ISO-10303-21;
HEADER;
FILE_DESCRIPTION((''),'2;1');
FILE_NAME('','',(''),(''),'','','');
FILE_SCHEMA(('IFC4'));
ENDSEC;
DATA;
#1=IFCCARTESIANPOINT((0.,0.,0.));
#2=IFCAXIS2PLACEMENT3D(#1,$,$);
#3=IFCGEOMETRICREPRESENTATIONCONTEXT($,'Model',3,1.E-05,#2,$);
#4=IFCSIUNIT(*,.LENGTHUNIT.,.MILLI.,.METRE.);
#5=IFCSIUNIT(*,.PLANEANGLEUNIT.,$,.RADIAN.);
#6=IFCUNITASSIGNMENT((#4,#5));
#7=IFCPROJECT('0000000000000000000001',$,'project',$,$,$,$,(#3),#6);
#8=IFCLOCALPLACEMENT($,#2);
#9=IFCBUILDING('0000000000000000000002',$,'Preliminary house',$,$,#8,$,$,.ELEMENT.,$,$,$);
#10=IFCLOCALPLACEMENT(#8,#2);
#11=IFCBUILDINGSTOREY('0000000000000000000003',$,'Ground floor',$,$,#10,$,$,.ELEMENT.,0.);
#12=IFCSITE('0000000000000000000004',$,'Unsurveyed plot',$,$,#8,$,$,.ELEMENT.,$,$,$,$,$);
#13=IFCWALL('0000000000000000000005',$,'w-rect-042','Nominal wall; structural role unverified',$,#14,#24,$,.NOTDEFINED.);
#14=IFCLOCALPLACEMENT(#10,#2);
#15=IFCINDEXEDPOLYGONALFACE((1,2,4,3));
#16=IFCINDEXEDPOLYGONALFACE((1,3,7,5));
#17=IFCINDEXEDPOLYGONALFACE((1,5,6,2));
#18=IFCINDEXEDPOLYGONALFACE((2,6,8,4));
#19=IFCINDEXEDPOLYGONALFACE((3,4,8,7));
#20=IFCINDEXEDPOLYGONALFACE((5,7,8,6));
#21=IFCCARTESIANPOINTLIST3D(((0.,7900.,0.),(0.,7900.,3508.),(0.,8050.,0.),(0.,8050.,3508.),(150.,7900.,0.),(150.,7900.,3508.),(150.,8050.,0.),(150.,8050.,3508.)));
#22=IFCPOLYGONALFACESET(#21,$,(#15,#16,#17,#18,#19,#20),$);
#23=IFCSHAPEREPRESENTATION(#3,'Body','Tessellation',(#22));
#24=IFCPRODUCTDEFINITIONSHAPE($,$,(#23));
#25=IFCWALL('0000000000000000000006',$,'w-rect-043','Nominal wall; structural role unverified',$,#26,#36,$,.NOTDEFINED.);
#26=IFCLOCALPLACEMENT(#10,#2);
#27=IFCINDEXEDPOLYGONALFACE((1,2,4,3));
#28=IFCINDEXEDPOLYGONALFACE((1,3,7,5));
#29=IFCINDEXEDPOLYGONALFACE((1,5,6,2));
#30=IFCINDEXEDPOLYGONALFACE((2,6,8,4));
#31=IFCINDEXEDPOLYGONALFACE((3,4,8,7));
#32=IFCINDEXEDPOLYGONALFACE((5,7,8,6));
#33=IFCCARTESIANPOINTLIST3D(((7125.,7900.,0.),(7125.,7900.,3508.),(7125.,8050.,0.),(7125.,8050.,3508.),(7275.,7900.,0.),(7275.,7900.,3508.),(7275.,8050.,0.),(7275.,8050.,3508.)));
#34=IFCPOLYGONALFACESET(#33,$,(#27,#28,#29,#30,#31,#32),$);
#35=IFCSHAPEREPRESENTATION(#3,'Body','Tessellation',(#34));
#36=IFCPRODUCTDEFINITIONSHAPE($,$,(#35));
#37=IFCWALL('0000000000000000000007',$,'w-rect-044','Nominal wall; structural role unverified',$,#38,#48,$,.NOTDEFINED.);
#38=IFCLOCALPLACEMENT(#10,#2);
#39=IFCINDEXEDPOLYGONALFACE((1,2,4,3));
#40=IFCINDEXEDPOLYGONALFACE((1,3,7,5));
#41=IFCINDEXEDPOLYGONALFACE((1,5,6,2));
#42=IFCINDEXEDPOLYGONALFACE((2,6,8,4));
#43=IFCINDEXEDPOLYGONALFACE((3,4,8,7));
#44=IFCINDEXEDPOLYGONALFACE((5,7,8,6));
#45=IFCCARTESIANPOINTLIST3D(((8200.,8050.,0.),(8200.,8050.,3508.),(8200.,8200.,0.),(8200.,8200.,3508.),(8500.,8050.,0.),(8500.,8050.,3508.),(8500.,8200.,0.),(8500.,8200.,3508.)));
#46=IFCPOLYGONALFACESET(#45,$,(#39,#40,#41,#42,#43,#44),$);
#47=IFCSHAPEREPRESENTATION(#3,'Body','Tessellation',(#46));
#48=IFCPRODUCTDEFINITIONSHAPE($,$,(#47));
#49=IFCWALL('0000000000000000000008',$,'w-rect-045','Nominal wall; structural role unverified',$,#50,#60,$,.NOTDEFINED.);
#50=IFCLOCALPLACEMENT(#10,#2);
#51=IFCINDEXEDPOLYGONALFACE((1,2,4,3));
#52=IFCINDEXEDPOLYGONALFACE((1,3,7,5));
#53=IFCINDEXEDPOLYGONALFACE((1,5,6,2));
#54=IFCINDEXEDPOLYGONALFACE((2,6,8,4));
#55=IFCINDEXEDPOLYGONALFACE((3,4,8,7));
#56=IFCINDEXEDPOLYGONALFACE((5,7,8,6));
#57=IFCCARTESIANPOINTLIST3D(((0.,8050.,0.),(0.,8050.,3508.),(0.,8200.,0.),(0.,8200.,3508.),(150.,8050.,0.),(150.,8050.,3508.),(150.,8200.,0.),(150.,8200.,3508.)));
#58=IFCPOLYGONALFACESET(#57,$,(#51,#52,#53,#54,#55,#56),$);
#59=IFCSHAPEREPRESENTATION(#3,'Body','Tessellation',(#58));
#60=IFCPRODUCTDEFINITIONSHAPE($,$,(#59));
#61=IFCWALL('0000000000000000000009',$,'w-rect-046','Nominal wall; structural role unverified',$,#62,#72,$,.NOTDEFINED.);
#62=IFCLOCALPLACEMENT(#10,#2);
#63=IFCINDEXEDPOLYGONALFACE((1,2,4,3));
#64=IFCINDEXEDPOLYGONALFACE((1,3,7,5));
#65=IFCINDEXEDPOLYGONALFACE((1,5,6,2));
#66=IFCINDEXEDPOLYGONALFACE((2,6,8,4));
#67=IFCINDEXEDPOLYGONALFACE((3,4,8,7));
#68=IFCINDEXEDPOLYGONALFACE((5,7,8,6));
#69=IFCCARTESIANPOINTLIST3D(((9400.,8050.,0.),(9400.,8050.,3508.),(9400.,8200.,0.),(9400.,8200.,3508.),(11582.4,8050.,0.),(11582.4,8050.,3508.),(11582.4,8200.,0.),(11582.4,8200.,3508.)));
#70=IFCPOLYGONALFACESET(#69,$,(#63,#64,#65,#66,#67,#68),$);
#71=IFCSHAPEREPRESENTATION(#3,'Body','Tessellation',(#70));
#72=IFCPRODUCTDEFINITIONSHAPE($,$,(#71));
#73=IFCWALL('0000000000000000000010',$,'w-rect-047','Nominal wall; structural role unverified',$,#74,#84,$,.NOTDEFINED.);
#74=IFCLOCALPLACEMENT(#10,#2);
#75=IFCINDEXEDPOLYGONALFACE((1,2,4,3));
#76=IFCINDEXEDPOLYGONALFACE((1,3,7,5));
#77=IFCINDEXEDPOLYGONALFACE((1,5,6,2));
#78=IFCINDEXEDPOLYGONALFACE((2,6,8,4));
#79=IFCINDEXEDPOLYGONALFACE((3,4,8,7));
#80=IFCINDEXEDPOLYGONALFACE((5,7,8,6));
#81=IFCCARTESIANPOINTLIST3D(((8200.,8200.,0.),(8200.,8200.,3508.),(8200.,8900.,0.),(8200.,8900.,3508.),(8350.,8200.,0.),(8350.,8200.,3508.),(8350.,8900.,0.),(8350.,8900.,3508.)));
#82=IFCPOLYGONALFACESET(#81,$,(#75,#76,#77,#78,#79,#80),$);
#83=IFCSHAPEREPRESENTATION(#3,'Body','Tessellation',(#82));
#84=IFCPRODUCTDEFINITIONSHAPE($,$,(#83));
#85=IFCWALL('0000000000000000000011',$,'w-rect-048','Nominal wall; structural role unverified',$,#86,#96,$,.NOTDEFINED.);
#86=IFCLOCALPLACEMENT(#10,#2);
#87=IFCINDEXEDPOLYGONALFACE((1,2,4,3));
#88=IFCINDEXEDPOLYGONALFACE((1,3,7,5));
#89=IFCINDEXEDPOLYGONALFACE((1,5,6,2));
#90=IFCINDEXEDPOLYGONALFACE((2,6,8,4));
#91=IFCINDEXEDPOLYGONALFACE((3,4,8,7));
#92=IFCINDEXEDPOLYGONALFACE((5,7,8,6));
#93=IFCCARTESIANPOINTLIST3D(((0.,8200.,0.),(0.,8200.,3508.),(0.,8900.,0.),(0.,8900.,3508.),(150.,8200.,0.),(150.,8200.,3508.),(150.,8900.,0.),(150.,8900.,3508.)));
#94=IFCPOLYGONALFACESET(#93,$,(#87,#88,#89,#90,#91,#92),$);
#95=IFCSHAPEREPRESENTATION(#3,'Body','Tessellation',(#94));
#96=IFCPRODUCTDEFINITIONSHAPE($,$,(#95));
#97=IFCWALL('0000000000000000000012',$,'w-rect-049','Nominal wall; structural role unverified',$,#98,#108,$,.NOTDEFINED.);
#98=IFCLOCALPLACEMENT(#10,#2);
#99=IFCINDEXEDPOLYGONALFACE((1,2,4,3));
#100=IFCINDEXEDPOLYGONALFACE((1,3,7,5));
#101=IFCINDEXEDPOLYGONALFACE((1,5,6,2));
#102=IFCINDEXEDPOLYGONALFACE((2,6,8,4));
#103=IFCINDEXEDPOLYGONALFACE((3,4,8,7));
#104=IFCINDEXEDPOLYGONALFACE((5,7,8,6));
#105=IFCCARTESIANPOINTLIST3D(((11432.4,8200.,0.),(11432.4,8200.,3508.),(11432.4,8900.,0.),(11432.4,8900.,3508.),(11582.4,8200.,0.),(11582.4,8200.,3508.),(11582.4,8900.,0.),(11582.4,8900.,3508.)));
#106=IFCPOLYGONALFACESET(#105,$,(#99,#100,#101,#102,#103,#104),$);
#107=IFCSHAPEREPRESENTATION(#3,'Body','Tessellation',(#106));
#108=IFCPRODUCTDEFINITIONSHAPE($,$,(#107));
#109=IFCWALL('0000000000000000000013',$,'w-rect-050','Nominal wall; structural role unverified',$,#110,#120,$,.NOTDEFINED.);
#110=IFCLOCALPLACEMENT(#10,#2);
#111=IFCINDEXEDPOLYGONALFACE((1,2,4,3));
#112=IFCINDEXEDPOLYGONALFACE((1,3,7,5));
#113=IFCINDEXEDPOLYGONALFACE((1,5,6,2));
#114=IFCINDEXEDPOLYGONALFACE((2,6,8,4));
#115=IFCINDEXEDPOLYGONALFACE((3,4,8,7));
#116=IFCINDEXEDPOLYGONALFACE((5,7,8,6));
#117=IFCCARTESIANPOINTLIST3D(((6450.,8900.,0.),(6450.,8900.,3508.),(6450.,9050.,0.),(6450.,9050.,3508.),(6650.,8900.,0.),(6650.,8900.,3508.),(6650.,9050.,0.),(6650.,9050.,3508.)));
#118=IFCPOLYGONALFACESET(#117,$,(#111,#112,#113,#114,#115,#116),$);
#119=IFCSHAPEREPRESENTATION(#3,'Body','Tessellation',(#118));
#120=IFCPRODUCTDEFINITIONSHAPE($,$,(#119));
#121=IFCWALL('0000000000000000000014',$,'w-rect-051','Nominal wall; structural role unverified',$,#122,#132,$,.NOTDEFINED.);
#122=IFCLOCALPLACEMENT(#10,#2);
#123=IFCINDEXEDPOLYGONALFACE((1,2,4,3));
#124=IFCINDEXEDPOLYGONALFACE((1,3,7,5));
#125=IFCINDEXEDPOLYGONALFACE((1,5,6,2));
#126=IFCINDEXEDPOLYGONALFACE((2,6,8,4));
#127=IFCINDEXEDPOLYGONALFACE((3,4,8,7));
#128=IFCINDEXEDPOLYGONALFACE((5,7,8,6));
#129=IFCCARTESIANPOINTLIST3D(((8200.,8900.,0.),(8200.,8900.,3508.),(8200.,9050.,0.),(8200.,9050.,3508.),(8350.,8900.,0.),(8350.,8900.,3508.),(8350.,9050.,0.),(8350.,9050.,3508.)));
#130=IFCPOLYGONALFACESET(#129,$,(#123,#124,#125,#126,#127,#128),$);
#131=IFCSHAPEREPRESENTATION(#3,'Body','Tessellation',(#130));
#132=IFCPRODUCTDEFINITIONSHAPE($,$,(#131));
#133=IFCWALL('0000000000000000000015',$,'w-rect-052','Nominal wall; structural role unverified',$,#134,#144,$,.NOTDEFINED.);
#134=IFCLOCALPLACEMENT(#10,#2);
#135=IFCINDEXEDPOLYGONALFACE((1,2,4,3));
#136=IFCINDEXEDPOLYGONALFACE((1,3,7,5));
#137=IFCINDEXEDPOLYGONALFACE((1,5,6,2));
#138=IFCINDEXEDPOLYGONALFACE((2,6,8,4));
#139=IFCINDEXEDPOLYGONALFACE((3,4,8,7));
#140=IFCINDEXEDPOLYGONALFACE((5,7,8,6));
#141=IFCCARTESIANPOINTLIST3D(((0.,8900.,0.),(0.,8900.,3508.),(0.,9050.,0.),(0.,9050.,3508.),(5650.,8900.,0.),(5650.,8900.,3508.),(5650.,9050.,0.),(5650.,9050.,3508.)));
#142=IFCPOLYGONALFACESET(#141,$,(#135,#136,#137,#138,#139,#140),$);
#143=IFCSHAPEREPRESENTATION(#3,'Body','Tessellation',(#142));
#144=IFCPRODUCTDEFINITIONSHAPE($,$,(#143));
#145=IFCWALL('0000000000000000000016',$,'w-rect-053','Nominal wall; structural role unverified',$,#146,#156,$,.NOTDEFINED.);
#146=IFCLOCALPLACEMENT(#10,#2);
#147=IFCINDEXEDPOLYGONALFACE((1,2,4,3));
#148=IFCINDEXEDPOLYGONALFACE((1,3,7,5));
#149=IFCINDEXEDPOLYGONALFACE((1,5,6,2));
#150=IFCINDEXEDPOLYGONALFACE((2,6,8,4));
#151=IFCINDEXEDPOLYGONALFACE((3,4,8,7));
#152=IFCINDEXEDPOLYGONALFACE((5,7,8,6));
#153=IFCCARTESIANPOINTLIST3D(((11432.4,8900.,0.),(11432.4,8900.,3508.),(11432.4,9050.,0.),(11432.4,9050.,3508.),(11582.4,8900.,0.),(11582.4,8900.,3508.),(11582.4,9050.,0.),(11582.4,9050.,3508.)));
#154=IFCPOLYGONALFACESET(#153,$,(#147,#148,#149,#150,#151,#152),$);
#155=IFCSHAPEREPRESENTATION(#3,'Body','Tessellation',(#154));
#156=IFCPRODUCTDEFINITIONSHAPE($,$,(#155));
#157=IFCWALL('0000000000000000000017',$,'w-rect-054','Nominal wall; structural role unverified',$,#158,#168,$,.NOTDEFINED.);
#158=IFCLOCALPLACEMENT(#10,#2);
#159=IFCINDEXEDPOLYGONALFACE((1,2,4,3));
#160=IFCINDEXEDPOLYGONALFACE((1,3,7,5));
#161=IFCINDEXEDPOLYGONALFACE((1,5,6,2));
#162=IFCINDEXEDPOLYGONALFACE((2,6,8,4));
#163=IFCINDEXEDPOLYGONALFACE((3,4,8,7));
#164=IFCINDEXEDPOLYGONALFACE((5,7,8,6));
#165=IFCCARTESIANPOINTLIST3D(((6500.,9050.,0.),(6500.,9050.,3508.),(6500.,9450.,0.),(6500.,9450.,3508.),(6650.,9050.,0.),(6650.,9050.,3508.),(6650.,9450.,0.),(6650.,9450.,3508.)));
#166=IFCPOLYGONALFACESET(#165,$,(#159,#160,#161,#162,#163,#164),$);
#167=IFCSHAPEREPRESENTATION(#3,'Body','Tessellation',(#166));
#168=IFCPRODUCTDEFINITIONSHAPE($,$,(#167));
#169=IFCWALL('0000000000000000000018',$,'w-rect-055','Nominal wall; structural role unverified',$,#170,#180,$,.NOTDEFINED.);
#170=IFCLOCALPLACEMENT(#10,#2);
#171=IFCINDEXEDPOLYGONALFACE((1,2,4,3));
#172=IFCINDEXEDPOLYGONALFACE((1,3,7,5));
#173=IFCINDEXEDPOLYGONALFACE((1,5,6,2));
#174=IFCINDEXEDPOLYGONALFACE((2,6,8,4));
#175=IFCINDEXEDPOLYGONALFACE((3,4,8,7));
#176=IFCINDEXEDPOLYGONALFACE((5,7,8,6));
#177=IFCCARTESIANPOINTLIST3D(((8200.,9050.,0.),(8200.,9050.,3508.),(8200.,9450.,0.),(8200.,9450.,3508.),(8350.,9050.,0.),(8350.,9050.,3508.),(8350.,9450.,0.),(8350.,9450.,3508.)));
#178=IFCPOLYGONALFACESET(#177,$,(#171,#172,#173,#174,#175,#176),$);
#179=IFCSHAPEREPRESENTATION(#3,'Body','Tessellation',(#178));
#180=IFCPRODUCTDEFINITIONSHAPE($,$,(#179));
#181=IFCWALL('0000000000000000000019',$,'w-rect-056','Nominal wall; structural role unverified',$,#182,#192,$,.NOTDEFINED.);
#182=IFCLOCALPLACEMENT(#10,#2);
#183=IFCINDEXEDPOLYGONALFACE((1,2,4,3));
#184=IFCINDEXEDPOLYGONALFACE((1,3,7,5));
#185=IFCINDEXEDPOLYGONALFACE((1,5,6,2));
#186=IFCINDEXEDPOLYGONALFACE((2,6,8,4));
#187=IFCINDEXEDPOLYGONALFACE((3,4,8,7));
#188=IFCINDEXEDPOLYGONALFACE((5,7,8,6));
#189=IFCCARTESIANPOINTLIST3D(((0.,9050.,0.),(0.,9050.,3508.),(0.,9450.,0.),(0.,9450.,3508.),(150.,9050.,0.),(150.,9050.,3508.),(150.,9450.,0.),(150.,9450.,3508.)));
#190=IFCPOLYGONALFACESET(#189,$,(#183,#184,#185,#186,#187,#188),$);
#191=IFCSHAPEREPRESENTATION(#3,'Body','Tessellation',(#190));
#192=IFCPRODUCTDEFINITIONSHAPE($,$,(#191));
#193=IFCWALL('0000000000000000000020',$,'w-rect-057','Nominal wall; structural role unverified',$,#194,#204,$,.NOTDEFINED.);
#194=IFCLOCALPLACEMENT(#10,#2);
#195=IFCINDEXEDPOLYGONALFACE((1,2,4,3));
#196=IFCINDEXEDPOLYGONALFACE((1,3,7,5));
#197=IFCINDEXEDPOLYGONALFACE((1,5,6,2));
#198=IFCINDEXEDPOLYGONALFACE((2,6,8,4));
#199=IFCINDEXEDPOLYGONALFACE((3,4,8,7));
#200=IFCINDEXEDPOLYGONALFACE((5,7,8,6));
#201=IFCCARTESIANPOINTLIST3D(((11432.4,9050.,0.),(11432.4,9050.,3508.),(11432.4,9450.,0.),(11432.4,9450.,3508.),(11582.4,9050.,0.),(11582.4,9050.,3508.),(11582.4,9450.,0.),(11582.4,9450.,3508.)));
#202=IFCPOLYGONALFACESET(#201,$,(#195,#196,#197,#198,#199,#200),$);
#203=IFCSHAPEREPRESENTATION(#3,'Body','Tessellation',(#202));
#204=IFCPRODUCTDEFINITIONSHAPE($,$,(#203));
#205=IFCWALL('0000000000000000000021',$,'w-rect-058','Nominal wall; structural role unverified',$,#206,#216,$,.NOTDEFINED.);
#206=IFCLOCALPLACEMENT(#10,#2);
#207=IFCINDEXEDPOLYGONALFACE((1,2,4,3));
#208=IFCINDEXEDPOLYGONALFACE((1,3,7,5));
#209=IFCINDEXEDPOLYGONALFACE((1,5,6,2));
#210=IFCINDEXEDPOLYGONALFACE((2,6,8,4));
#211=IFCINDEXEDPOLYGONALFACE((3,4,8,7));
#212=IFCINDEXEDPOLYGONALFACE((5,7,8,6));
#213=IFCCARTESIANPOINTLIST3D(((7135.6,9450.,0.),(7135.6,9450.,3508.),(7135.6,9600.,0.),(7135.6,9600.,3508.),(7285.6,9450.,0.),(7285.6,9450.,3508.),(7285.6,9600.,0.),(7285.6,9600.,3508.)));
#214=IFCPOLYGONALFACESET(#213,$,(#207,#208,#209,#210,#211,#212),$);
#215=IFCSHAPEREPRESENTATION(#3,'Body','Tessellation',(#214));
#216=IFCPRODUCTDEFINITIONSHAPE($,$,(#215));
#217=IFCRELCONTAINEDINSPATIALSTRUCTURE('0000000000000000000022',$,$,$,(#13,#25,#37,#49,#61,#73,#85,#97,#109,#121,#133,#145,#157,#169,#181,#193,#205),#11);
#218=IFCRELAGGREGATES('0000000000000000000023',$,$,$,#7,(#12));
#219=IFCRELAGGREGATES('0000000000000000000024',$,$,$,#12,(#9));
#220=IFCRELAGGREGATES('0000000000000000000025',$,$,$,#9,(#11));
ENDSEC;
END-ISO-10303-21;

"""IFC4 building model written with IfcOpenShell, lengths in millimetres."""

from ifc_helpers import new_model, si_unit, origin, place, context, project, spatial, polyline, outline, extrude, element, save


model = new_model("IFC4")

# Units and contexts
model_context = context("Model", 3, precision=1e-05, world=origin())
ifc_project = project(units=[si_unit("LENGTHUNIT", "METRE", prefix="MILLI"), si_unit("PLANEANGLEUNIT", "RADIAN")], contexts=[model_context])

# Site, building, storey
placement_1 = place(None, origin())
site = spatial("IfcSite", under=ifc_project, at=placement_1, Name="Unsurveyed plot", CompositionType="ELEMENT")
building = spatial("IfcBuilding", under=site, at=placement_1, Name="Preliminary house", CompositionType="ELEMENT")
placement_2 = place(placement_1, origin())
storey = spatial("IfcBuildingStorey", under=building, at=placement_2, Name="Ground floor", CompositionType="ELEMENT", Elevation=0.0)

# Walls
element("IfcWall", 1, at=placement_2, inside=storey, Name="w-rect-042", Description="Nominal wall; structural role unverified", PredefinedType="NOTDEFINED", context=model_context, shape_type="SweptSolid", body=[
    extrude(outline(polyline([(0.0, 7900.0), (150.0, 7900.0), (150.0, 8050.0), (0.0, 8050.0), (0.0, 7900.0)])), origin(), (0.0, 0.0, 1.0), 3508.0),
])
element("IfcWall", 2, at=placement_2, inside=storey, Name="w-rect-043", Description="Nominal wall; structural role unverified", PredefinedType="NOTDEFINED", context=model_context, shape_type="SweptSolid", body=[
    extrude(outline(polyline([(7125.0, 7900.0), (7275.0, 7900.0), (7275.0, 8050.0), (7125.0, 8050.0), (7125.0, 7900.0)])), origin(), (0.0, 0.0, 1.0), 3508.0),
])
element("IfcWall", 3, at=placement_2, inside=storey, Name="w-rect-044", Description="Nominal wall; structural role unverified", PredefinedType="NOTDEFINED", context=model_context, shape_type="SweptSolid", body=[
    extrude(outline(polyline([(8200.0, 8050.0), (8500.0, 8050.0), (8500.0, 8200.0), (8200.0, 8200.0), (8200.0, 8050.0)])), origin(), (0.0, 0.0, 1.0), 3508.0),
])
element("IfcWall", 4, at=placement_2, inside=storey, Name="w-rect-045", Description="Nominal wall; structural role unverified", PredefinedType="NOTDEFINED", context=model_context, shape_type="SweptSolid", body=[
    extrude(outline(polyline([(0.0, 8050.0), (150.0, 8050.0), (150.0, 8200.0), (0.0, 8200.0), (0.0, 8050.0)])), origin(), (0.0, 0.0, 1.0), 3508.0),
])
element("IfcWall", 5, at=placement_2, inside=storey, Name="w-rect-046", Description="Nominal wall; structural role unverified", PredefinedType="NOTDEFINED", context=model_context, shape_type="SweptSolid", body=[
    extrude(outline(polyline([(9400.0, 8050.0), (11582.4, 8050.0), (11582.4, 8200.0), (9400.0, 8200.0), (9400.0, 8050.0)])), origin(), (0.0, 0.0, 1.0), 3508.0),
])
element("IfcWall", 6, at=placement_2, inside=storey, Name="w-rect-047", Description="Nominal wall; structural role unverified", PredefinedType="NOTDEFINED", context=model_context, shape_type="SweptSolid", body=[
    extrude(outline(polyline([(8200.0, 8200.0), (8350.0, 8200.0), (8350.0, 8900.0), (8200.0, 8900.0), (8200.0, 8200.0)])), origin(), (0.0, 0.0, 1.0), 3508.0),
])
element("IfcWall", 7, at=placement_2, inside=storey, Name="w-rect-048", Description="Nominal wall; structural role unverified", PredefinedType="NOTDEFINED", context=model_context, shape_type="SweptSolid", body=[
    extrude(outline(polyline([(0.0, 8200.0), (150.0, 8200.0), (150.0, 8900.0), (0.0, 8900.0), (0.0, 8200.0)])), origin(), (0.0, 0.0, 1.0), 3508.0),
])
element("IfcWall", 8, at=placement_2, inside=storey, Name="w-rect-049", Description="Nominal wall; structural role unverified", PredefinedType="NOTDEFINED", context=model_context, shape_type="SweptSolid", body=[
    extrude(outline(polyline([(11432.4, 8200.0), (11582.4, 8200.0), (11582.4, 8900.0), (11432.4, 8900.0), (11432.4, 8200.0)])), origin(), (0.0, 0.0, 1.0), 3508.0),
])
element("IfcWall", 9, at=placement_2, inside=storey, Name="w-rect-050", Description="Nominal wall; structural role unverified", PredefinedType="NOTDEFINED", context=model_context, shape_type="SweptSolid", body=[
    extrude(outline(polyline([(6450.0, 8900.0), (6650.0, 8900.0), (6650.0, 9050.0), (6450.0, 9050.0), (6450.0, 8900.0)])), origin(), (0.0, 0.0, 1.0), 3508.0),
])
element("IfcWall", 10, at=placement_2, inside=storey, Name="w-rect-051", Description="Nominal wall; structural role unverified", PredefinedType="NOTDEFINED", context=model_context, shape_type="SweptSolid", body=[
    extrude(outline(polyline([(8200.0, 8900.0), (8350.0, 8900.0), (8350.0, 9050.0), (8200.0, 9050.0), (8200.0, 8900.0)])), origin(), (0.0, 0.0, 1.0), 3508.0),
])
element("IfcWall", 11, at=placement_2, inside=storey, Name="w-rect-052", Description="Nominal wall; structural role unverified", PredefinedType="NOTDEFINED", context=model_context, shape_type="SweptSolid", body=[
    extrude(outline(polyline([(0.0, 8900.0), (5650.0, 8900.0), (5650.0, 9050.0), (0.0, 9050.0), (0.0, 8900.0)])), origin(), (0.0, 0.0, 1.0), 3508.0),
])
element("IfcWall", 12, at=placement_2, inside=storey, Name="w-rect-053", Description="Nominal wall; structural role unverified", PredefinedType="NOTDEFINED", context=model_context, shape_type="SweptSolid", body=[
    extrude(outline(polyline([(11432.4, 8900.0), (11582.4, 8900.0), (11582.4, 9050.0), (11432.4, 9050.0), (11432.4, 8900.0)])), origin(), (0.0, 0.0, 1.0), 3508.0),
])
element("IfcWall", 13, at=placement_2, inside=storey, Name="w-rect-054", Description="Nominal wall; structural role unverified", PredefinedType="NOTDEFINED", context=model_context, shape_type="SweptSolid", body=[
    extrude(outline(polyline([(6500.0, 9050.0), (6650.0, 9050.0), (6650.0, 9450.0), (6500.0, 9450.0), (6500.0, 9050.0)])), origin(), (0.0, 0.0, 1.0), 3508.0),
])
element("IfcWall", 14, at=placement_2, inside=storey, Name="w-rect-055", Description="Nominal wall; structural role unverified", PredefinedType="NOTDEFINED", context=model_context, shape_type="SweptSolid", body=[
    extrude(outline(polyline([(8200.0, 9050.0), (8350.0, 9050.0), (8350.0, 9450.0), (8200.0, 9450.0), (8200.0, 9050.0)])), origin(), (0.0, 0.0, 1.0), 3508.0),
])
element("IfcWall", 15, at=placement_2, inside=storey, Name="w-rect-056", Description="Nominal wall; structural role unverified", PredefinedType="NOTDEFINED", context=model_context, shape_type="SweptSolid", body=[
    extrude(outline(polyline([(0.0, 9050.0), (150.0, 9050.0), (150.0, 9450.0), (0.0, 9450.0), (0.0, 9050.0)])), origin(), (0.0, 0.0, 1.0), 3508.0),
])
element("IfcWall", 16, at=placement_2, inside=storey, Name="w-rect-057", Description="Nominal wall; structural role unverified", PredefinedType="NOTDEFINED", context=model_context, shape_type="SweptSolid", body=[
    extrude(outline(polyline([(11432.4, 9050.0), (11582.4, 9050.0), (11582.4, 9450.0), (11432.4, 9450.0), (11432.4, 9050.0)])), origin(), (0.0, 0.0, 1.0), 3508.0),
])
element("IfcWall", 17, at=placement_2, inside=storey, Name="w-rect-058", Description="Nominal wall; structural role unverified", PredefinedType="NOTDEFINED", context=model_context, shape_type="SweptSolid", body=[
    extrude(outline(polyline([(7135.6, 9450.0), (7285.6, 9450.0), (7285.6, 9600.0), (7135.6, 9600.0), (7135.6, 9450.0)])), origin(), (0.0, 0.0, 1.0), 3508.0),
])

save(model, "model.ifc")
